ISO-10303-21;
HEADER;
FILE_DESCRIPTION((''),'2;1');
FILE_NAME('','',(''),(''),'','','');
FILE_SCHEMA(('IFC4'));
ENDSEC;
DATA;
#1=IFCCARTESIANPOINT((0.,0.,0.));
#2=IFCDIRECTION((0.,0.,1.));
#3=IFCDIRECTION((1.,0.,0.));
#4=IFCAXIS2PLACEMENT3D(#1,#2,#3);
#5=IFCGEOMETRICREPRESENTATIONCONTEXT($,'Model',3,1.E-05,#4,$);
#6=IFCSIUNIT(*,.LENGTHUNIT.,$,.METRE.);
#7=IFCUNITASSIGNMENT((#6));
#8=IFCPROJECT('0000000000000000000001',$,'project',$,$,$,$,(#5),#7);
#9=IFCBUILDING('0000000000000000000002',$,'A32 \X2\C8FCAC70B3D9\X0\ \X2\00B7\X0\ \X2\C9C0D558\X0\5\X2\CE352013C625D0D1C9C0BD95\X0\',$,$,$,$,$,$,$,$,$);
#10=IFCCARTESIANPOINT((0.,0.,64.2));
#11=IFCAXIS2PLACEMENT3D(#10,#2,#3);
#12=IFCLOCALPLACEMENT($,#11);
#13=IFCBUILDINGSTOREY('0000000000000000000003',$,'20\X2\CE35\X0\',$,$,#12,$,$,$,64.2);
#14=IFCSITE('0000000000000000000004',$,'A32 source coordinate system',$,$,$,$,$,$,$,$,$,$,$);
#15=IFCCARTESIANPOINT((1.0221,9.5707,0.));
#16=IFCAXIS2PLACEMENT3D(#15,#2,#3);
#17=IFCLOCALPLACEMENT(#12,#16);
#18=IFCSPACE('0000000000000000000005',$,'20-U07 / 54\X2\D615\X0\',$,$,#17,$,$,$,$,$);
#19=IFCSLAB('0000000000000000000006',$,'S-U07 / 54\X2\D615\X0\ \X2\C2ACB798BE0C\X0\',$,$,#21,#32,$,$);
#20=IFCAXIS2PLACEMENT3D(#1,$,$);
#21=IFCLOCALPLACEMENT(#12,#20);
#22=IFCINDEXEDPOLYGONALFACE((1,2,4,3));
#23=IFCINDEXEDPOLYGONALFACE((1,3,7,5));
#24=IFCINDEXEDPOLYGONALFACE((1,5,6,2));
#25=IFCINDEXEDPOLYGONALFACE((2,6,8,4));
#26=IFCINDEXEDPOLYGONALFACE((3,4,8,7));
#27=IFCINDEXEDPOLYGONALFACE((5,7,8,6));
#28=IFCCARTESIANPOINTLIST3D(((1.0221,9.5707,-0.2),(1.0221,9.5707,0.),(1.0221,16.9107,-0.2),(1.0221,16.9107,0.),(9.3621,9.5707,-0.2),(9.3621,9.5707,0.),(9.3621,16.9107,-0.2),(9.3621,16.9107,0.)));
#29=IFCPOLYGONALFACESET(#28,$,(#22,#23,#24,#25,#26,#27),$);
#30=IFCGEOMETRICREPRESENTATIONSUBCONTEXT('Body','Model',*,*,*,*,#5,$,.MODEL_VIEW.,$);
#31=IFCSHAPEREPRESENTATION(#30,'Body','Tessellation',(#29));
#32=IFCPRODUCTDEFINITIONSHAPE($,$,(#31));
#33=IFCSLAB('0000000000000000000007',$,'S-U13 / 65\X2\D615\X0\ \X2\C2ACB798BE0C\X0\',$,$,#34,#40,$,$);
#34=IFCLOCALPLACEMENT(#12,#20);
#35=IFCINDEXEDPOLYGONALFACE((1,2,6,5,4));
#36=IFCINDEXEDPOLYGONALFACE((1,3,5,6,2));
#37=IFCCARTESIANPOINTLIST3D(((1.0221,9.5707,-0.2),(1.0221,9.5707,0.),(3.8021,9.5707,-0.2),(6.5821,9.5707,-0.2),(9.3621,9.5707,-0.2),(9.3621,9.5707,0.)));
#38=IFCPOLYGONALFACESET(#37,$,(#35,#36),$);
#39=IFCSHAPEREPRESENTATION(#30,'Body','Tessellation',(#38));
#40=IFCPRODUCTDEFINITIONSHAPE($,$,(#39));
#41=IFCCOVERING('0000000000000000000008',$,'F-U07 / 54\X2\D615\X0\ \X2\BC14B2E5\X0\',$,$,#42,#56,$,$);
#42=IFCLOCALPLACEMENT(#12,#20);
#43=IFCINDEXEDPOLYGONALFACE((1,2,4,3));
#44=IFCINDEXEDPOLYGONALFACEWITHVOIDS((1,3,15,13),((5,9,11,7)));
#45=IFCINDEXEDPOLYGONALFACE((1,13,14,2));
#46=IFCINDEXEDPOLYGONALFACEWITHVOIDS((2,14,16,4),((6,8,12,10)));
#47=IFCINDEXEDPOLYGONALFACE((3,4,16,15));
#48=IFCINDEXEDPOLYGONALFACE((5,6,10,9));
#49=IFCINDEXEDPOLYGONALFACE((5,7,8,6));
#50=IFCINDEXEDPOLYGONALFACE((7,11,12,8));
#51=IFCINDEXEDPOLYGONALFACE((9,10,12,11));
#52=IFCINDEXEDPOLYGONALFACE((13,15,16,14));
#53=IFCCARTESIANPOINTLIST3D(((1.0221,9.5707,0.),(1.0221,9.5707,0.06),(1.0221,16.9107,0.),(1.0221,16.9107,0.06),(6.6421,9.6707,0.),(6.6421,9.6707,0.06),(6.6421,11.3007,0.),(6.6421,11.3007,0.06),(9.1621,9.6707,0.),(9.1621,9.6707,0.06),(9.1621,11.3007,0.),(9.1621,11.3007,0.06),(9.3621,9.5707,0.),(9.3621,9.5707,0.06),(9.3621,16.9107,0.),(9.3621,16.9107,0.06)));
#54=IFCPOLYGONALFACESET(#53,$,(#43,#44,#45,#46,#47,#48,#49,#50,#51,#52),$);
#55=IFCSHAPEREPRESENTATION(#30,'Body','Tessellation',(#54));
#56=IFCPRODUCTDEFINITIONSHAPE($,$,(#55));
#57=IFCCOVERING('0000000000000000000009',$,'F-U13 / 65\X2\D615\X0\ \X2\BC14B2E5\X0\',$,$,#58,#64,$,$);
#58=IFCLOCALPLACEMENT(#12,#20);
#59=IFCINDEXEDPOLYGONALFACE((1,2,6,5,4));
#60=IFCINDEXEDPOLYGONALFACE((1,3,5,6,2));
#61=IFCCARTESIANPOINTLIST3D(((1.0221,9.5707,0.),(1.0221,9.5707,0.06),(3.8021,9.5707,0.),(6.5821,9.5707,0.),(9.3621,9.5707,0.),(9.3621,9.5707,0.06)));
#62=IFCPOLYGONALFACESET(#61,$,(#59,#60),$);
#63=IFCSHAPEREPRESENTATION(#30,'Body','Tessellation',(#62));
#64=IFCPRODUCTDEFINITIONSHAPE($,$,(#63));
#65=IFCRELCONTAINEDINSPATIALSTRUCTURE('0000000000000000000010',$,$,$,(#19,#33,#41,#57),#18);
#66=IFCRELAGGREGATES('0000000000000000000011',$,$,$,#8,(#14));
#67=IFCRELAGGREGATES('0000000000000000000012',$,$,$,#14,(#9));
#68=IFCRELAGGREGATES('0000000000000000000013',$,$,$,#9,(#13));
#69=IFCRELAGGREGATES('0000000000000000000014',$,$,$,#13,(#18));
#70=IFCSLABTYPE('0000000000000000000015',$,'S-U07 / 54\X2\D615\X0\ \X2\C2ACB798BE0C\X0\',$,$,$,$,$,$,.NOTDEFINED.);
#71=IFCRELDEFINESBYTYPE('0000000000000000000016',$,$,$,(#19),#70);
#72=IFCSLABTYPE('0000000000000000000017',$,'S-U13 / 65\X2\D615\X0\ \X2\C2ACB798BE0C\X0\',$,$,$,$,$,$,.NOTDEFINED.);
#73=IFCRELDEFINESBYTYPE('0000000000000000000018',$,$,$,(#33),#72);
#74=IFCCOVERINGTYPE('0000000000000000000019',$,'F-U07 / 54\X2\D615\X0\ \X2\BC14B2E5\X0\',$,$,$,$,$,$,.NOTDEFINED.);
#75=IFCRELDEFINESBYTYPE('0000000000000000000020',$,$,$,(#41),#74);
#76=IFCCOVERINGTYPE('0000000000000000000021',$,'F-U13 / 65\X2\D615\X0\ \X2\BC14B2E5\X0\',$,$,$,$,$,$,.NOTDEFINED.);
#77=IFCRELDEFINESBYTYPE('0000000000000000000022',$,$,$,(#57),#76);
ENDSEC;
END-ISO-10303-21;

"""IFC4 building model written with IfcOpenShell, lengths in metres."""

from ifc_helpers import new_model, si_unit, frame, origin, origin_with_axes, place, context, subcontext, project, spatial, polyline, outline, extrude, source, transform, mapped, type_object, type_shapes, element, save


model = new_model("IFC4")

# Units and contexts
model_context = context("Model", 3, precision=1e-05, world=origin_with_axes())
body_context = subcontext(model_context, "Body", "Model", "MODEL_VIEW")
ifc_project = project(units=[si_unit("LENGTHUNIT", "METRE")], contexts=[model_context])

# Site, building, storey, space
storey_placement = place(None, frame((0.0, 0.0, 64.2), z_axis=(0.0, 0.0, 1.0), x_axis=(1.0, 0.0, 0.0)))
space_placement = place(storey_placement, frame((1.0221, 9.5707, 0.0), z_axis=(0.0, 0.0, 1.0), x_axis=(1.0, 0.0, 0.0)))
site = spatial("IfcSite", under=ifc_project, Name="A32 source coordinate system")
building = spatial("IfcBuilding", under=site, Name="A32 주거동 · 지하5층–옥탑지붕")
storey = spatial("IfcBuildingStorey", under=building, at=storey_placement, Name="20층", Elevation=64.2)
space = spatial("IfcSpace", under=storey, at=space_placement, Name="20-U07 / 54형")

# Slabs
slab_type_1 = type_object("IfcSlabType", Name="S-U07 / 54형 슬래브", PredefinedType="NOTDEFINED")
shared_shape_1 = source(origin(), body_context, "Body", "SweptSolid", [
    extrude(outline(polyline([(0.0, 0.0), (0.0, 7.34), (8.34, 7.34), (8.34, 0.0), (0.0, 0.0)])), frame((0.0, 0.0, -0.2)), (0.0, 0.0, 1.0), 0.2),
])
type_shapes(slab_type_1, [shared_shape_1])
slab_1_placement = place(space_placement, origin_with_axes())
element("IfcSlab", 1, at=slab_1_placement, inside=space, type_object=slab_type_1, Name="S-U07 / 54형 슬래브", context=body_context, shape_type="MappedRepresentation", body=[
    mapped(shared_shape_1, transform((0.0, 0.0, 0.0), scale=1.0)),
])
slab_type_2 = type_object("IfcSlabType", Name="S-U13 / 65형 슬래브", PredefinedType="NOTDEFINED")
shared_shape_2 = source(origin(), body_context, "Body", "SweptSolid", [
    extrude(outline(polyline([(0.0, 0.0), (8.34, 0.0), (8.34, 0.0), (0.0, 0.0), (0.0, 0.0)])), frame((0.0, 0.0, -0.2)), (0.0, 0.0, 1.0), 0.2),
])
type_shapes(slab_type_2, [shared_shape_2])
slab_2_placement = place(space_placement, origin_with_axes())
element("IfcSlab", 2, at=slab_2_placement, inside=space, type_object=slab_type_2, Name="S-U13 / 65형 슬래브", context=body_context, shape_type="MappedRepresentation", body=[
    mapped(shared_shape_2, transform((0.0, 0.0, 0.0), scale=1.0)),
])

# Coverings
covering_type_1 = type_object("IfcCoveringType", Name="F-U07 / 54형 바닥", PredefinedType="NOTDEFINED")
shared_shape_3 = source(origin(), body_context, "Body", "SweptSolid", [
    extrude(outline(polyline([(0.0, 0.0), (0.0, 7.34), (8.34, 7.34), (8.34, 0.0), (0.0, 0.0)]), holes=[polyline([(5.62, 1.73), (5.62, 0.1), (8.14, 0.1), (8.14, 1.73), (5.62, 1.73)])]), origin(), (0.0, 0.0, 1.0), 0.06),
])
type_shapes(covering_type_1, [shared_shape_3])
covering_1_placement = place(space_placement, origin_with_axes())
element("IfcCovering", 3, at=covering_1_placement, inside=space, type_object=covering_type_1, Name="F-U07 / 54형 바닥", context=body_context, shape_type="MappedRepresentation", body=[
    mapped(shared_shape_3, transform((0.0, 0.0, 0.0), scale=1.0)),
])
covering_type_2 = type_object("IfcCoveringType", Name="F-U13 / 65형 바닥", PredefinedType="NOTDEFINED")
shared_shape_4 = source(origin(), body_context, "Body", "SweptSolid", [
    extrude(outline(polyline([(0.0, 0.0), (8.34, 0.0), (8.34, 0.0), (0.0, 0.0), (0.0, 0.0)])), origin(), (0.0, 0.0, 1.0), 0.06),
])
type_shapes(covering_type_2, [shared_shape_4])
covering_2_placement = place(space_placement, origin_with_axes())
element("IfcCovering", 4, at=covering_2_placement, inside=space, type_object=covering_type_2, Name="F-U13 / 65형 바닥", context=body_context, shape_type="MappedRepresentation", body=[
    mapped(shared_shape_4, transform((0.0, 0.0, 0.0), scale=1.0)),
])

save(model, "model.ifc")
